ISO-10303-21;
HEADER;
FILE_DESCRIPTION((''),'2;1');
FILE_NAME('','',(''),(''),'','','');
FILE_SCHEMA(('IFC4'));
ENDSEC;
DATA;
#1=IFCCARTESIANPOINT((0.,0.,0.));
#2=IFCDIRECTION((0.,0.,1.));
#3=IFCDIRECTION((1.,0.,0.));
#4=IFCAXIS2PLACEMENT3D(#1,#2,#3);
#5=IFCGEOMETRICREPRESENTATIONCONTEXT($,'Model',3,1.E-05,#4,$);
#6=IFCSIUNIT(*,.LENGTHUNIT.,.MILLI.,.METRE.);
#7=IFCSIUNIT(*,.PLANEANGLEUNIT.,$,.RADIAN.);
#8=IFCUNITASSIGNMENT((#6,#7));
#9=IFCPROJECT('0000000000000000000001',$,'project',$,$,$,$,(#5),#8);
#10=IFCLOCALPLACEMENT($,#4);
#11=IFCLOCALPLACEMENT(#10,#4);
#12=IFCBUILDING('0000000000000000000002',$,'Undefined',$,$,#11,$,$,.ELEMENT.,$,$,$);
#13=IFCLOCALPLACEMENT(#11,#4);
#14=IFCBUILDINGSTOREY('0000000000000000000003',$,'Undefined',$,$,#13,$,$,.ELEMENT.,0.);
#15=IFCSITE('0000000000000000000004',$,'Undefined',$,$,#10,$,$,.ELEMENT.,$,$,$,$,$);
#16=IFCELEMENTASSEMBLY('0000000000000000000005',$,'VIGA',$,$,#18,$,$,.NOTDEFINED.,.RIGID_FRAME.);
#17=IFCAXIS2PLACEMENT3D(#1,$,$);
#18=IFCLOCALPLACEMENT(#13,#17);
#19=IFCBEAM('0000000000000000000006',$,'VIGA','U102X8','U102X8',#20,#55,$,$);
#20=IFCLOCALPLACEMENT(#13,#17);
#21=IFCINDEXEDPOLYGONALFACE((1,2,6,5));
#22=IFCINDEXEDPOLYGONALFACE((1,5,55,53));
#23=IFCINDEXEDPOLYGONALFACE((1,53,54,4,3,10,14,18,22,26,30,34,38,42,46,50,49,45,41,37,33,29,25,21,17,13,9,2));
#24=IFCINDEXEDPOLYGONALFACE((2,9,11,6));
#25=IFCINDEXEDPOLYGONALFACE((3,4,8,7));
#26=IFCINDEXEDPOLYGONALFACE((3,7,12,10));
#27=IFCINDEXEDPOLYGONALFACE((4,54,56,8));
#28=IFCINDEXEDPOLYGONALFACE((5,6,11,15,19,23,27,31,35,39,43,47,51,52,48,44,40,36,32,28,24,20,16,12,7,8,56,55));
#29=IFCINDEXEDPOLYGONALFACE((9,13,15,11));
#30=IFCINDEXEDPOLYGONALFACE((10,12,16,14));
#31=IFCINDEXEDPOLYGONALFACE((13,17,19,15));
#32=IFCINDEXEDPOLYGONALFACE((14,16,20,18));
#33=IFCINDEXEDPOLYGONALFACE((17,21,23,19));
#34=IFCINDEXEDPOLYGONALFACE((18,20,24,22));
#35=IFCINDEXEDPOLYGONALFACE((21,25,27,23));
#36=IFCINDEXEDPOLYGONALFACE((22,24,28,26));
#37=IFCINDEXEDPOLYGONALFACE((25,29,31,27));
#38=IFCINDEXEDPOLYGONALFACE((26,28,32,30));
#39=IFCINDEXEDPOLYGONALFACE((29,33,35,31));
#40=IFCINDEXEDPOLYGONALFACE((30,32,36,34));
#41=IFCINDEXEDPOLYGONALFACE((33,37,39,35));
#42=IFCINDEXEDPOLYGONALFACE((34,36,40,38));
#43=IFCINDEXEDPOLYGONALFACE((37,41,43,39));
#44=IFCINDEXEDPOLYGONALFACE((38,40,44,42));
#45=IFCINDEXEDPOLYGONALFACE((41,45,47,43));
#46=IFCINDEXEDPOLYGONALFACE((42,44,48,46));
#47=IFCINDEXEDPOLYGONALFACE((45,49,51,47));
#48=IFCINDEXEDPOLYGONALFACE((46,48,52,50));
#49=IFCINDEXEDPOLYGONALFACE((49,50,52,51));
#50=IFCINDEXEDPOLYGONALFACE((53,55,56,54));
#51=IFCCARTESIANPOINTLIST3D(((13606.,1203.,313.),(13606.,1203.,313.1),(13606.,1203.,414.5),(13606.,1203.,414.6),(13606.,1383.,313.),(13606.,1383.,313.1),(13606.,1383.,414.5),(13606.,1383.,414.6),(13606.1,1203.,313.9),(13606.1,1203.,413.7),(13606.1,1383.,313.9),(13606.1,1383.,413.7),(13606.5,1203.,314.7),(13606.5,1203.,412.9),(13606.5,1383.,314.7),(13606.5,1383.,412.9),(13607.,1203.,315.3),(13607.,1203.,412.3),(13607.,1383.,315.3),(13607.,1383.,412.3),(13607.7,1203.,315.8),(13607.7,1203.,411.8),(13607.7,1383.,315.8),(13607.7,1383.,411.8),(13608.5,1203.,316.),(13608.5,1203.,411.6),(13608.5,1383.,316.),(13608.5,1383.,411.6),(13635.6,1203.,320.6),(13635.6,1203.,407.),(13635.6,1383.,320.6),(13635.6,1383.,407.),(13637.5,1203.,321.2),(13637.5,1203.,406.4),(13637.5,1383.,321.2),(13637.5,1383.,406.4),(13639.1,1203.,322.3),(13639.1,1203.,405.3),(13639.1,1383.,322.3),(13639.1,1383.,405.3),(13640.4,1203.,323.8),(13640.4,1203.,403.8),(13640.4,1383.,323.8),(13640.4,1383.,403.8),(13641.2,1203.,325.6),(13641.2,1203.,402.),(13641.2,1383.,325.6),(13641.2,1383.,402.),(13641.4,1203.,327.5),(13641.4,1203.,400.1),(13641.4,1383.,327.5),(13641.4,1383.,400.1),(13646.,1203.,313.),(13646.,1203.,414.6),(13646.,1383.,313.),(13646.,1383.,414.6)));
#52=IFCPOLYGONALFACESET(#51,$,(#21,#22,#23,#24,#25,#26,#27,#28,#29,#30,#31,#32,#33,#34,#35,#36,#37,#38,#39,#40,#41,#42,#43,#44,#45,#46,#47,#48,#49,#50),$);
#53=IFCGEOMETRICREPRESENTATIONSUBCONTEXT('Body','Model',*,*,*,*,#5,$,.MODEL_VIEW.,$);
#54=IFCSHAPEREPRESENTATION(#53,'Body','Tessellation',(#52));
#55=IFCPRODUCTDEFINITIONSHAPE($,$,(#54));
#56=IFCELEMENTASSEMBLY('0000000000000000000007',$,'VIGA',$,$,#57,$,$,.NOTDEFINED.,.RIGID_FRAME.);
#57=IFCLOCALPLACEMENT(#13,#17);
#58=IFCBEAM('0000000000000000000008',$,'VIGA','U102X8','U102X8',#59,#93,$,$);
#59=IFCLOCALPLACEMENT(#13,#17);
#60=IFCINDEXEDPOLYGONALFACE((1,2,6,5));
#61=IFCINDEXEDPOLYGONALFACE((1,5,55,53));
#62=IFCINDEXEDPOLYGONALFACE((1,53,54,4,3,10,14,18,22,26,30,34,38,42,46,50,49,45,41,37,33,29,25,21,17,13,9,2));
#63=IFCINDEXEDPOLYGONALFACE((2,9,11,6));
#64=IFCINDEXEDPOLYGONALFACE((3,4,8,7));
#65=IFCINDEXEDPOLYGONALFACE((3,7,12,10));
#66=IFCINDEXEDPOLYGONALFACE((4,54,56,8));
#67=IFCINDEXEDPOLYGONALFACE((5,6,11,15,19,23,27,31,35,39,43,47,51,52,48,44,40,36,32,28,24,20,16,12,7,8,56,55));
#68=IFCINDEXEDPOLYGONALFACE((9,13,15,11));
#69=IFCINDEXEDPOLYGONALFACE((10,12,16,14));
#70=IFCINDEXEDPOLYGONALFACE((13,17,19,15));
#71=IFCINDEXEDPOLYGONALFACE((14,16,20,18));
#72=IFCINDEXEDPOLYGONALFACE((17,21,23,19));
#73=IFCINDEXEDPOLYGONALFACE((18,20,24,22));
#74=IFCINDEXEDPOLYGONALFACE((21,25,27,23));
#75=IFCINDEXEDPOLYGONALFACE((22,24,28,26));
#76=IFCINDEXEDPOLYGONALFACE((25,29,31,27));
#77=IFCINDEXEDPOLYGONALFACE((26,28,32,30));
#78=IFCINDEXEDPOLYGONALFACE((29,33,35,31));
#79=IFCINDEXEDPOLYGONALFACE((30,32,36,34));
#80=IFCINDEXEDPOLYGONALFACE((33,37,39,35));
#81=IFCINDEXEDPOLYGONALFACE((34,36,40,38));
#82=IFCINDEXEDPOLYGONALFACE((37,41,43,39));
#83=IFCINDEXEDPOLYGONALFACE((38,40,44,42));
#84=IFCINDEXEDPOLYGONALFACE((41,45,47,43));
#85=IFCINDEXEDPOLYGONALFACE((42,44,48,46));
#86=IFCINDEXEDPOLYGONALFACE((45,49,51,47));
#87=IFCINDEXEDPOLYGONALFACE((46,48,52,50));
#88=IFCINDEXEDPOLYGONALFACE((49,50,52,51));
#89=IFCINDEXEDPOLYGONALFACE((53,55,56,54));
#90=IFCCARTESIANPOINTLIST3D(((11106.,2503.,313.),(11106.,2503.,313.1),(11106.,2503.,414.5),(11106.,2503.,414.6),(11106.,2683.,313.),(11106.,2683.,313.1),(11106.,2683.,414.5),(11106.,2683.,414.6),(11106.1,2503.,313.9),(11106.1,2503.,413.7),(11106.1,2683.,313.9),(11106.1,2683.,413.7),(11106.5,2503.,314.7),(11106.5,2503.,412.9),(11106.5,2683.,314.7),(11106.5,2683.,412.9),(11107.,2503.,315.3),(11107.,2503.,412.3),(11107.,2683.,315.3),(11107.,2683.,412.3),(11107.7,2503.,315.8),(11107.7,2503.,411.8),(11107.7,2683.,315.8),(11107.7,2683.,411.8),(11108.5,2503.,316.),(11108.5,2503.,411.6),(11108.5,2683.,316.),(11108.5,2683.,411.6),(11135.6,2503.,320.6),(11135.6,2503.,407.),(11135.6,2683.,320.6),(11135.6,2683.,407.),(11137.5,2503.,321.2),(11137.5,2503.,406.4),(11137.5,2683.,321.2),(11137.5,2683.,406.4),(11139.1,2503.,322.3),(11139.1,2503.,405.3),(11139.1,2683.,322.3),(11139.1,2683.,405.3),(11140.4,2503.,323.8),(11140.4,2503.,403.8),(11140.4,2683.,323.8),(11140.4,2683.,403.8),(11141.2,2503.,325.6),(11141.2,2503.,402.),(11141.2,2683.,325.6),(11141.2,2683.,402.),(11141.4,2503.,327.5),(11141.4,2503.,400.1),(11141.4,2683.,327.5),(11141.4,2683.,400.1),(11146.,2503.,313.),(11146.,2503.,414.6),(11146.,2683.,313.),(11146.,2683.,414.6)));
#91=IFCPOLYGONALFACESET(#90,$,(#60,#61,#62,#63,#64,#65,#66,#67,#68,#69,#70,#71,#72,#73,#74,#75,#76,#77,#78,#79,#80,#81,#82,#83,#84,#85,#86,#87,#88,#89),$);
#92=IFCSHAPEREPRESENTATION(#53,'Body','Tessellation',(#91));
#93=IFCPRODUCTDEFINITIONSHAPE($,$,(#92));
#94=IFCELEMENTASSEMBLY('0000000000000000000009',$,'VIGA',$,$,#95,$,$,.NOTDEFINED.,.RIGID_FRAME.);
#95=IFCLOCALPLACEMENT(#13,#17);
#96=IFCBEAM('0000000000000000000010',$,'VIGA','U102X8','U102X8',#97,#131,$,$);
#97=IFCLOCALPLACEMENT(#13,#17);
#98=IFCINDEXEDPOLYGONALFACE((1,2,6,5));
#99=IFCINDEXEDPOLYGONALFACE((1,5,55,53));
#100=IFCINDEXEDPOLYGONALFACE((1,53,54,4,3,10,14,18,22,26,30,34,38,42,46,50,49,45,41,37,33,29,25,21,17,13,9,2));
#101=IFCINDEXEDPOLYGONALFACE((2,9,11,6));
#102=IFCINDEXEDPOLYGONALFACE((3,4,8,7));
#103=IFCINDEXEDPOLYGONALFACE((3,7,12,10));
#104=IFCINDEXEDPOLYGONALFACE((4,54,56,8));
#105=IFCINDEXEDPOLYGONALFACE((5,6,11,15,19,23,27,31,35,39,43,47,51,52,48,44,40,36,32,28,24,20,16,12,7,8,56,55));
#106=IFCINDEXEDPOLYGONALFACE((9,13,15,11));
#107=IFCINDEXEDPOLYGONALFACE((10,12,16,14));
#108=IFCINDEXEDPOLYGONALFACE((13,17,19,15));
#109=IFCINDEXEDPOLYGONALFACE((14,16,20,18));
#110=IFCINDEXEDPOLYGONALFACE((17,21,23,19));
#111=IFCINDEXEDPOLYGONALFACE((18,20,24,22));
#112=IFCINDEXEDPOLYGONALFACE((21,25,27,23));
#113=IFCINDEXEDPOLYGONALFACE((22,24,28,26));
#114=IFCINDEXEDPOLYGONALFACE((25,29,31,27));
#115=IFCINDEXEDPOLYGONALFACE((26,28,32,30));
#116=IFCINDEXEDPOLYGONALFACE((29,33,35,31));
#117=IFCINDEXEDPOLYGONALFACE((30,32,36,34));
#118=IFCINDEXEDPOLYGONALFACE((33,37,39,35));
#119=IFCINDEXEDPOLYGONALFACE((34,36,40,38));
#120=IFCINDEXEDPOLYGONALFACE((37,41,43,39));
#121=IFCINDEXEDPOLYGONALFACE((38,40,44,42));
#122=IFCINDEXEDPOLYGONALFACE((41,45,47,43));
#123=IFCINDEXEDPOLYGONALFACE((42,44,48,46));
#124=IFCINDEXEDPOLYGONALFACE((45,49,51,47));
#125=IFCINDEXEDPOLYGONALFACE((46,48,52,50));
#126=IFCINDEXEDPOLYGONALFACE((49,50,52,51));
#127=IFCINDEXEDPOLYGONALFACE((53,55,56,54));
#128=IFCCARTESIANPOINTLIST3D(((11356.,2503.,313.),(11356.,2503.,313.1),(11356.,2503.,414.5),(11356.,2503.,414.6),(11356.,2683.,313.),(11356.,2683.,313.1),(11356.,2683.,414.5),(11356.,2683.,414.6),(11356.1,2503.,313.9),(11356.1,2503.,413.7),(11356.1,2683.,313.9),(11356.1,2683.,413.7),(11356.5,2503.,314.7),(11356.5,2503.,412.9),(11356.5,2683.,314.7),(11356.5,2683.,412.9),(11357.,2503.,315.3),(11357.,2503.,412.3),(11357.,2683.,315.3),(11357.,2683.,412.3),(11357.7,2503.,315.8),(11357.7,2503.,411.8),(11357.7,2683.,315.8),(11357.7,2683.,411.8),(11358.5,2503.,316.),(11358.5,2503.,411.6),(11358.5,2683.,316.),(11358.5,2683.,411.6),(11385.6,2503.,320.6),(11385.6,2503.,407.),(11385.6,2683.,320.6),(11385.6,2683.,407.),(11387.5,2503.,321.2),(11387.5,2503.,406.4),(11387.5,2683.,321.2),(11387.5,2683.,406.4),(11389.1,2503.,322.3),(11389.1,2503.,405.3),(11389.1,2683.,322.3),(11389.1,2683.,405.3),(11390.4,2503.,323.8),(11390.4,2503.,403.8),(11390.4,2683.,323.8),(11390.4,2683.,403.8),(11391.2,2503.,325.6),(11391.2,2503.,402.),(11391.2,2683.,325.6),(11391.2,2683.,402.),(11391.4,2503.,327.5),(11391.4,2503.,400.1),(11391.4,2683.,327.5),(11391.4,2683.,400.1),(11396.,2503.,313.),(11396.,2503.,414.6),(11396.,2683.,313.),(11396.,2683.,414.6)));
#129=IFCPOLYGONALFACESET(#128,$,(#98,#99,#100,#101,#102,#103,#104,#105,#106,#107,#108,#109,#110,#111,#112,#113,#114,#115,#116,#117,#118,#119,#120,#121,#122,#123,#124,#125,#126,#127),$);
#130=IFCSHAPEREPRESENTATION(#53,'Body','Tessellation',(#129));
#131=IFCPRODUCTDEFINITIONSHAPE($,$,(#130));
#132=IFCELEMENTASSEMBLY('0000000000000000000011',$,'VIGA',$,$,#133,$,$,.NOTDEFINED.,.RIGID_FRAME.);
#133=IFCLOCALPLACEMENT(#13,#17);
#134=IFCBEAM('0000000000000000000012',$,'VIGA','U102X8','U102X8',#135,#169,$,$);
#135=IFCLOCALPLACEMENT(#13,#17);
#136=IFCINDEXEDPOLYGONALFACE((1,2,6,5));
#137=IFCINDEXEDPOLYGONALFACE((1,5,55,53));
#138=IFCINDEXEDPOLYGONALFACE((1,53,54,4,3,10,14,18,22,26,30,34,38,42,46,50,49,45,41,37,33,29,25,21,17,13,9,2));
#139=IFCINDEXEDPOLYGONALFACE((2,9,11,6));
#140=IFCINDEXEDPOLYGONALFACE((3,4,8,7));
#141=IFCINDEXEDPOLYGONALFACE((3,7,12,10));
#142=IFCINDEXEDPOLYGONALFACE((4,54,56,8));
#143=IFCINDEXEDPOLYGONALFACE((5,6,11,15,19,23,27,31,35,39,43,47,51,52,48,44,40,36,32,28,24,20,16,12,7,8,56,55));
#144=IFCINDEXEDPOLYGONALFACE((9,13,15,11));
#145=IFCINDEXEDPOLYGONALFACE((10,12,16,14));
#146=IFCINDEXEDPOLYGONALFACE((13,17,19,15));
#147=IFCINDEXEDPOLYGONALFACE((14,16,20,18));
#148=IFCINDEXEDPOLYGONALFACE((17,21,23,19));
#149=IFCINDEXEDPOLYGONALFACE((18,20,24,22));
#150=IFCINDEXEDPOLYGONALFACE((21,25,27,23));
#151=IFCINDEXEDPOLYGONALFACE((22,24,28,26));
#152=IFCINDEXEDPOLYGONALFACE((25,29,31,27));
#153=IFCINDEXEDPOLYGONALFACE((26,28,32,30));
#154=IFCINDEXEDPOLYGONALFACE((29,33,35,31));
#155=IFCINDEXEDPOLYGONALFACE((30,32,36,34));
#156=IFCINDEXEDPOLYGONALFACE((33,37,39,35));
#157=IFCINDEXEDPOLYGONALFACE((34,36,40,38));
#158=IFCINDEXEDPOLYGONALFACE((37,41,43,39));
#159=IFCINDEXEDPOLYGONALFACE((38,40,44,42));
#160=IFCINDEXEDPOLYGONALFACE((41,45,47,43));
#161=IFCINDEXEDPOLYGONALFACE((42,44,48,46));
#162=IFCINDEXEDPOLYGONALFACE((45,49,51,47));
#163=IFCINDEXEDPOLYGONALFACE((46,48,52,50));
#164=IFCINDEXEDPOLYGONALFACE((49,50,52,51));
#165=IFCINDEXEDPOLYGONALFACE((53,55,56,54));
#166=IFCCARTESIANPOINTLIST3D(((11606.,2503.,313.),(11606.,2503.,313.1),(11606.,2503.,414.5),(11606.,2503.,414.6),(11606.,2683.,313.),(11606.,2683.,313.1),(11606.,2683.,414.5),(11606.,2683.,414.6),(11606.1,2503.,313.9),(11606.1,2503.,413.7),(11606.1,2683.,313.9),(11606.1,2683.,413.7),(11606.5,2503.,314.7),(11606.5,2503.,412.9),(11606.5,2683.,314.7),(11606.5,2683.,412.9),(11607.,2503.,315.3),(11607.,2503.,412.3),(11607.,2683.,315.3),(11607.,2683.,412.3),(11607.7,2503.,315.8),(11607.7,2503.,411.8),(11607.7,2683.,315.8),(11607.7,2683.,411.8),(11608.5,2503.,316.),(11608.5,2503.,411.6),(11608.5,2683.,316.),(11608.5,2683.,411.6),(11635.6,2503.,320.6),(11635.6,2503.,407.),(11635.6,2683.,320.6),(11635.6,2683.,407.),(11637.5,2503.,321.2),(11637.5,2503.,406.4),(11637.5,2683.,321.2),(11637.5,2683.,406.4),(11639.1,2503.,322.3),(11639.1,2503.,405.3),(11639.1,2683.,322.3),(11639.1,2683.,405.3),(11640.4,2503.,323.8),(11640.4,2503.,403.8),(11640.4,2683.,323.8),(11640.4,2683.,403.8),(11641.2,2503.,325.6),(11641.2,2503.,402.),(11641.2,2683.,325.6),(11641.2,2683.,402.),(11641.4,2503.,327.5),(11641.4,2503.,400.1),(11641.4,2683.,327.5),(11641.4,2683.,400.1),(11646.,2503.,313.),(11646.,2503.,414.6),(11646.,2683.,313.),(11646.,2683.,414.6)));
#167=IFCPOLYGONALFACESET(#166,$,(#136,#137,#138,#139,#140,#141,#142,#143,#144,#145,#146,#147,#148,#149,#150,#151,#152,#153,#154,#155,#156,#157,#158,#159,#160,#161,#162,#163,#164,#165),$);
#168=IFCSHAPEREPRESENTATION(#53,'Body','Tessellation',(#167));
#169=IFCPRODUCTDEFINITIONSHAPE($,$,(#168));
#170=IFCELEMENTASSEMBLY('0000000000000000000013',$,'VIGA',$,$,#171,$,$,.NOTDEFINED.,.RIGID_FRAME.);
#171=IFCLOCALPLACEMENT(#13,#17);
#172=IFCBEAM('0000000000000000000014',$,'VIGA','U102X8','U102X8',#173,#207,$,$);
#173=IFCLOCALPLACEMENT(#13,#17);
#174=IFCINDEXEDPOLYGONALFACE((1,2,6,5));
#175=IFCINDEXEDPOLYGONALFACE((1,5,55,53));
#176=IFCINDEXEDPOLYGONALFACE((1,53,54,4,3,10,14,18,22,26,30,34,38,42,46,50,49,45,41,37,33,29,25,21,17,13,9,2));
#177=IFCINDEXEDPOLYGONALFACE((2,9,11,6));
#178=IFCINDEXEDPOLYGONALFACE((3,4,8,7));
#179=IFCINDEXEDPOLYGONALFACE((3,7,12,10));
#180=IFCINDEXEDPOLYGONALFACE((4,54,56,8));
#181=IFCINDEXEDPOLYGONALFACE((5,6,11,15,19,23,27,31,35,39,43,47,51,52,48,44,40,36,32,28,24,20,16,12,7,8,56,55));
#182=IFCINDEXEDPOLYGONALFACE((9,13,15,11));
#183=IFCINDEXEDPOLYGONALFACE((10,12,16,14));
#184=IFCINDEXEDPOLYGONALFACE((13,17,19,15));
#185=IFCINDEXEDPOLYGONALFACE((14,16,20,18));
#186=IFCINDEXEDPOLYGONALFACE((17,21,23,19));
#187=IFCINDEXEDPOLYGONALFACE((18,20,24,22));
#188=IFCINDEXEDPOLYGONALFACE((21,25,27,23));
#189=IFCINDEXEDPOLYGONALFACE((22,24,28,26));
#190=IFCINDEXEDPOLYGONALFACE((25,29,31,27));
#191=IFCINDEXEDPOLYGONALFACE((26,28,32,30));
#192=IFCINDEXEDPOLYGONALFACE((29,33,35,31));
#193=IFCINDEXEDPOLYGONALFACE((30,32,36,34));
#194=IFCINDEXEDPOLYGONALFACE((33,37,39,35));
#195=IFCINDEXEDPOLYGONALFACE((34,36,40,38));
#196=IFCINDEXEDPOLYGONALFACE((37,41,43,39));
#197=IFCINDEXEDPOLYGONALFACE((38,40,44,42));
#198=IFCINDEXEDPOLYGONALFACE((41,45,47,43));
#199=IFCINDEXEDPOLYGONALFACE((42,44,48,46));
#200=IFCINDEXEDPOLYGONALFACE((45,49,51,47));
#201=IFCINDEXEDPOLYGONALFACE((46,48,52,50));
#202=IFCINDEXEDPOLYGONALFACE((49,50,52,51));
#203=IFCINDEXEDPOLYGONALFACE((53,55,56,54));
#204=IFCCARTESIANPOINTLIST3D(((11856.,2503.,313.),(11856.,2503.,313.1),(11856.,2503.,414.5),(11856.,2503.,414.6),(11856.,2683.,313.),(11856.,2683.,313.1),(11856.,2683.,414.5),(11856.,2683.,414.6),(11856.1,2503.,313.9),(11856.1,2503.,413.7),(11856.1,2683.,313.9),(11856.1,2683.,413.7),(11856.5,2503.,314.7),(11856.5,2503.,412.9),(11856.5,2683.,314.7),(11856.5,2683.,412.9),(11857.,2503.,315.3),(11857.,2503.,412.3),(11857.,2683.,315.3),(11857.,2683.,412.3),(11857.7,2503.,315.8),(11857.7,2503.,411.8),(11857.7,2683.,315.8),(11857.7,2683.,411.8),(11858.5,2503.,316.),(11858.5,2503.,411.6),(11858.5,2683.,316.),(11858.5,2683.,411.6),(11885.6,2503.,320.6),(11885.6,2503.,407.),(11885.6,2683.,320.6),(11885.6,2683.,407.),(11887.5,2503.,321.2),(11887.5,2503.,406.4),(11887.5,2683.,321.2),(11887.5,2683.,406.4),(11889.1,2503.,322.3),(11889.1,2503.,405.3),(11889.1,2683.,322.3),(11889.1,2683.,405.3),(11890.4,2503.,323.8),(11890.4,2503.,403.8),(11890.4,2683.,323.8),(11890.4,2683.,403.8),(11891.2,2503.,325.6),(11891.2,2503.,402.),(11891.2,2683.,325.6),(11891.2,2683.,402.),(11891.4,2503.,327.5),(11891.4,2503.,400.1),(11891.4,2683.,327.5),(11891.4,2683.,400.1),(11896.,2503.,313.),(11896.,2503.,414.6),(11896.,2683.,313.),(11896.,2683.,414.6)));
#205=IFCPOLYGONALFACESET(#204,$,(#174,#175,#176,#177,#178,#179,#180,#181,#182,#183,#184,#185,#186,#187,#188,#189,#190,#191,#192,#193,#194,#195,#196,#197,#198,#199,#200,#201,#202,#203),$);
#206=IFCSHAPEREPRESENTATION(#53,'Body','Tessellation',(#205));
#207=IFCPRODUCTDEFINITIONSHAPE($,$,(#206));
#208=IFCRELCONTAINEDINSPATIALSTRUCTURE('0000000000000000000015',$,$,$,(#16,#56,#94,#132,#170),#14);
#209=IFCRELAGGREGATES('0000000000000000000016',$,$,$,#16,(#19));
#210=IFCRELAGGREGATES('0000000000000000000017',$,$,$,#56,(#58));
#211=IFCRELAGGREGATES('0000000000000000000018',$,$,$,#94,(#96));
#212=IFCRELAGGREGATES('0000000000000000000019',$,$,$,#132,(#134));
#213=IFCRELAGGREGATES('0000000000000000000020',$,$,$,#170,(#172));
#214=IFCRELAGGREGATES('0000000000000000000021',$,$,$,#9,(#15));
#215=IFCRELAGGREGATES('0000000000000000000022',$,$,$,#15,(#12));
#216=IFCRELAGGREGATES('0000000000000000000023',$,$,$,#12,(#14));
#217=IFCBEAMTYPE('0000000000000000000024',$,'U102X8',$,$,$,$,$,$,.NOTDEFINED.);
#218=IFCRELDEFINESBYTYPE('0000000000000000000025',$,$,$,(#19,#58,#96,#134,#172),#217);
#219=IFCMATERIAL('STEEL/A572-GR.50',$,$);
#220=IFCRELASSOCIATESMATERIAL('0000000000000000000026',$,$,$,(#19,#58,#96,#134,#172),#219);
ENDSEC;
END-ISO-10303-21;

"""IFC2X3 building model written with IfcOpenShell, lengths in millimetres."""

from ifc_helpers import new_model, si_unit, frame, origin_with_axes, origin_2d_with_axis, place, context, subcontext, project, spatial, u_section, extrude, material, type_object, element, aggregate, save


model = new_model("IFC2X3")

# Units and contexts
model_context = context("Model", 3, precision=1e-05, world=origin_with_axes())
body_context = subcontext(model_context, "Body", "Model", "MODEL_VIEW")
ifc_project = project(units=[si_unit("LENGTHUNIT", "METRE", prefix="MILLI"), si_unit("PLANEANGLEUNIT", "RADIAN")], contexts=[model_context])

# Site, building, storey
site_placement = place(None, origin_with_axes())
site = spatial("IfcSite", under=ifc_project, at=site_placement, Name="Undefined", CompositionType="ELEMENT")
building_placement = place(site_placement, origin_with_axes())
building = spatial("IfcBuilding", under=site, at=building_placement, Name="Undefined", CompositionType="ELEMENT")
storey_placement = place(building_placement, origin_with_axes())
storey = spatial("IfcBuildingStorey", under=building, at=storey_placement, Name="Undefined", CompositionType="ELEMENT", Elevation=0.0)

# Element assemblies, beams
ifc_material = material(Name="STEEL/A572-GR.50")
beam_type = type_object("IfcBeamType", Name="U102X8", PredefinedType="NOTDEFINED")
assembly_1_placement = place(storey_placement, origin_with_axes())
assembly_1 = element("IfcElementAssembly", 1, at=assembly_1_placement, inside=storey, Name="VIGA", AssemblyPlace="NOTDEFINED", PredefinedType="RIGID_FRAME")
beam_1_placement = place(assembly_1_placement, frame((13626.0, 1383.0, 363.8), z_axis=(0.0, 0.0, 1.0), x_axis=(0.0, -1.0, 0.0)))
beam_1 = element("IfcBeam", 2, at=beam_1_placement, type_object=beam_type, material=ifc_material, Name="VIGA", Description="U102X8", ObjectType="U102X8", context=body_context, shape_type="SweptSolid", body=[
    extrude(u_section(Depth=101.6, FlangeWidth=40.0, WebThickness=4.6, FlangeThickness=6.0, FilletRadius=7.0, EdgeRadius=3.0, FlangeSlope=0.16839, at=origin_2d_with_axis()), frame((180.0, 0.0, 0.0), z_axis=(-1.0, 0.0, 0.0), x_axis=(0.0, -1.0, 0.0)), (0.0, 0.0, 1.0), 180.0),
])
aggregate(assembly_1, [beam_1])
assembly_2_placement = place(storey_placement, origin_with_axes())
assembly_2 = element("IfcElementAssembly", 3, at=assembly_2_placement, inside=storey, Name="VIGA", AssemblyPlace="NOTDEFINED", PredefinedType="RIGID_FRAME")
beam_2_placement = place(assembly_2_placement, frame((11126.0, 2683.0, 363.8), z_axis=(0.0, 0.0, 1.0), x_axis=(0.0, -1.0, 0.0)))
beam_2 = element("IfcBeam", 4, at=beam_2_placement, type_object=beam_type, material=ifc_material, Name="VIGA", Description="U102X8", ObjectType="U102X8", context=body_context, shape_type="SweptSolid", body=[
    extrude(u_section(Depth=101.6, FlangeWidth=40.0, WebThickness=4.6, FlangeThickness=6.0, FilletRadius=7.0, EdgeRadius=3.0, FlangeSlope=0.16839, at=origin_2d_with_axis()), frame((180.0, 0.0, 0.0), z_axis=(-1.0, 0.0, 0.0), x_axis=(0.0, -1.0, 0.0)), (0.0, 0.0, 1.0), 180.0),
])
aggregate(assembly_2, [beam_2])
assembly_3_placement = place(storey_placement, origin_with_axes())
assembly_3 = element("IfcElementAssembly", 5, at=assembly_3_placement, inside=storey, Name="VIGA", AssemblyPlace="NOTDEFINED", PredefinedType="RIGID_FRAME")
beam_3_placement = place(assembly_3_placement, frame((11376.0, 2683.0, 363.8), z_axis=(0.0, 0.0, 1.0), x_axis=(0.0, -1.0, 0.0)))
beam_3 = element("IfcBeam", 6, at=beam_3_placement, type_object=beam_type, material=ifc_material, Name="VIGA", Description="U102X8", ObjectType="U102X8", context=body_context, shape_type="SweptSolid", body=[
    extrude(u_section(Depth=101.6, FlangeWidth=40.0, WebThickness=4.6, FlangeThickness=6.0, FilletRadius=7.0, EdgeRadius=3.0, FlangeSlope=0.16839, at=origin_2d_with_axis()), frame((180.0, 0.0, 0.0), z_axis=(-1.0, 0.0, 0.0), x_axis=(0.0, -1.0, 0.0)), (0.0, 0.0, 1.0), 180.0),
])
aggregate(assembly_3, [beam_3])
assembly_4_placement = place(storey_placement, origin_with_axes())
assembly_4 = element("IfcElementAssembly", 7, at=assembly_4_placement, inside=storey, Name="VIGA", AssemblyPlace="NOTDEFINED", PredefinedType="RIGID_FRAME")
beam_4_placement = place(assembly_4_placement, frame((11626.0, 2683.0, 363.8), z_axis=(0.0, 0.0, 1.0), x_axis=(0.0, -1.0, 0.0)))
beam_4 = element("IfcBeam", 8, at=beam_4_placement, type_object=beam_type, material=ifc_material, Name="VIGA", Description="U102X8", ObjectType="U102X8", context=body_context, shape_type="SweptSolid", body=[
    extrude(u_section(Depth=101.6, FlangeWidth=40.0, WebThickness=4.6, FlangeThickness=6.0, FilletRadius=7.0, EdgeRadius=3.0, FlangeSlope=0.16839, at=origin_2d_with_axis()), frame((180.0, 0.0, 0.0), z_axis=(-1.0, 0.0, 0.0), x_axis=(0.0, -1.0, 0.0)), (0.0, 0.0, 1.0), 180.0),
])
aggregate(assembly_4, [beam_4])
assembly_5_placement = place(storey_placement, origin_with_axes())
assembly_5 = element("IfcElementAssembly", 9, at=assembly_5_placement, inside=storey, Name="VIGA", AssemblyPlace="NOTDEFINED", PredefinedType="RIGID_FRAME")
beam_5_placement = place(assembly_5_placement, frame((11876.0, 2683.0, 363.8), z_axis=(0.0, 0.0, 1.0), x_axis=(0.0, -1.0, 0.0)))
beam_5 = element("IfcBeam", 10, at=beam_5_placement, type_object=beam_type, material=ifc_material, Name="VIGA", Description="U102X8", ObjectType="U102X8", context=body_context, shape_type="SweptSolid", body=[
    extrude(u_section(Depth=101.6, FlangeWidth=40.0, WebThickness=4.6, FlangeThickness=6.0, FilletRadius=7.0, EdgeRadius=3.0, FlangeSlope=0.16839, at=origin_2d_with_axis()), frame((180.0, 0.0, 0.0), z_axis=(-1.0, 0.0, 0.0), x_axis=(0.0, -1.0, 0.0)), (0.0, 0.0, 1.0), 180.0),
])
aggregate(assembly_5, [beam_5])

save(model, "model.ifc")
